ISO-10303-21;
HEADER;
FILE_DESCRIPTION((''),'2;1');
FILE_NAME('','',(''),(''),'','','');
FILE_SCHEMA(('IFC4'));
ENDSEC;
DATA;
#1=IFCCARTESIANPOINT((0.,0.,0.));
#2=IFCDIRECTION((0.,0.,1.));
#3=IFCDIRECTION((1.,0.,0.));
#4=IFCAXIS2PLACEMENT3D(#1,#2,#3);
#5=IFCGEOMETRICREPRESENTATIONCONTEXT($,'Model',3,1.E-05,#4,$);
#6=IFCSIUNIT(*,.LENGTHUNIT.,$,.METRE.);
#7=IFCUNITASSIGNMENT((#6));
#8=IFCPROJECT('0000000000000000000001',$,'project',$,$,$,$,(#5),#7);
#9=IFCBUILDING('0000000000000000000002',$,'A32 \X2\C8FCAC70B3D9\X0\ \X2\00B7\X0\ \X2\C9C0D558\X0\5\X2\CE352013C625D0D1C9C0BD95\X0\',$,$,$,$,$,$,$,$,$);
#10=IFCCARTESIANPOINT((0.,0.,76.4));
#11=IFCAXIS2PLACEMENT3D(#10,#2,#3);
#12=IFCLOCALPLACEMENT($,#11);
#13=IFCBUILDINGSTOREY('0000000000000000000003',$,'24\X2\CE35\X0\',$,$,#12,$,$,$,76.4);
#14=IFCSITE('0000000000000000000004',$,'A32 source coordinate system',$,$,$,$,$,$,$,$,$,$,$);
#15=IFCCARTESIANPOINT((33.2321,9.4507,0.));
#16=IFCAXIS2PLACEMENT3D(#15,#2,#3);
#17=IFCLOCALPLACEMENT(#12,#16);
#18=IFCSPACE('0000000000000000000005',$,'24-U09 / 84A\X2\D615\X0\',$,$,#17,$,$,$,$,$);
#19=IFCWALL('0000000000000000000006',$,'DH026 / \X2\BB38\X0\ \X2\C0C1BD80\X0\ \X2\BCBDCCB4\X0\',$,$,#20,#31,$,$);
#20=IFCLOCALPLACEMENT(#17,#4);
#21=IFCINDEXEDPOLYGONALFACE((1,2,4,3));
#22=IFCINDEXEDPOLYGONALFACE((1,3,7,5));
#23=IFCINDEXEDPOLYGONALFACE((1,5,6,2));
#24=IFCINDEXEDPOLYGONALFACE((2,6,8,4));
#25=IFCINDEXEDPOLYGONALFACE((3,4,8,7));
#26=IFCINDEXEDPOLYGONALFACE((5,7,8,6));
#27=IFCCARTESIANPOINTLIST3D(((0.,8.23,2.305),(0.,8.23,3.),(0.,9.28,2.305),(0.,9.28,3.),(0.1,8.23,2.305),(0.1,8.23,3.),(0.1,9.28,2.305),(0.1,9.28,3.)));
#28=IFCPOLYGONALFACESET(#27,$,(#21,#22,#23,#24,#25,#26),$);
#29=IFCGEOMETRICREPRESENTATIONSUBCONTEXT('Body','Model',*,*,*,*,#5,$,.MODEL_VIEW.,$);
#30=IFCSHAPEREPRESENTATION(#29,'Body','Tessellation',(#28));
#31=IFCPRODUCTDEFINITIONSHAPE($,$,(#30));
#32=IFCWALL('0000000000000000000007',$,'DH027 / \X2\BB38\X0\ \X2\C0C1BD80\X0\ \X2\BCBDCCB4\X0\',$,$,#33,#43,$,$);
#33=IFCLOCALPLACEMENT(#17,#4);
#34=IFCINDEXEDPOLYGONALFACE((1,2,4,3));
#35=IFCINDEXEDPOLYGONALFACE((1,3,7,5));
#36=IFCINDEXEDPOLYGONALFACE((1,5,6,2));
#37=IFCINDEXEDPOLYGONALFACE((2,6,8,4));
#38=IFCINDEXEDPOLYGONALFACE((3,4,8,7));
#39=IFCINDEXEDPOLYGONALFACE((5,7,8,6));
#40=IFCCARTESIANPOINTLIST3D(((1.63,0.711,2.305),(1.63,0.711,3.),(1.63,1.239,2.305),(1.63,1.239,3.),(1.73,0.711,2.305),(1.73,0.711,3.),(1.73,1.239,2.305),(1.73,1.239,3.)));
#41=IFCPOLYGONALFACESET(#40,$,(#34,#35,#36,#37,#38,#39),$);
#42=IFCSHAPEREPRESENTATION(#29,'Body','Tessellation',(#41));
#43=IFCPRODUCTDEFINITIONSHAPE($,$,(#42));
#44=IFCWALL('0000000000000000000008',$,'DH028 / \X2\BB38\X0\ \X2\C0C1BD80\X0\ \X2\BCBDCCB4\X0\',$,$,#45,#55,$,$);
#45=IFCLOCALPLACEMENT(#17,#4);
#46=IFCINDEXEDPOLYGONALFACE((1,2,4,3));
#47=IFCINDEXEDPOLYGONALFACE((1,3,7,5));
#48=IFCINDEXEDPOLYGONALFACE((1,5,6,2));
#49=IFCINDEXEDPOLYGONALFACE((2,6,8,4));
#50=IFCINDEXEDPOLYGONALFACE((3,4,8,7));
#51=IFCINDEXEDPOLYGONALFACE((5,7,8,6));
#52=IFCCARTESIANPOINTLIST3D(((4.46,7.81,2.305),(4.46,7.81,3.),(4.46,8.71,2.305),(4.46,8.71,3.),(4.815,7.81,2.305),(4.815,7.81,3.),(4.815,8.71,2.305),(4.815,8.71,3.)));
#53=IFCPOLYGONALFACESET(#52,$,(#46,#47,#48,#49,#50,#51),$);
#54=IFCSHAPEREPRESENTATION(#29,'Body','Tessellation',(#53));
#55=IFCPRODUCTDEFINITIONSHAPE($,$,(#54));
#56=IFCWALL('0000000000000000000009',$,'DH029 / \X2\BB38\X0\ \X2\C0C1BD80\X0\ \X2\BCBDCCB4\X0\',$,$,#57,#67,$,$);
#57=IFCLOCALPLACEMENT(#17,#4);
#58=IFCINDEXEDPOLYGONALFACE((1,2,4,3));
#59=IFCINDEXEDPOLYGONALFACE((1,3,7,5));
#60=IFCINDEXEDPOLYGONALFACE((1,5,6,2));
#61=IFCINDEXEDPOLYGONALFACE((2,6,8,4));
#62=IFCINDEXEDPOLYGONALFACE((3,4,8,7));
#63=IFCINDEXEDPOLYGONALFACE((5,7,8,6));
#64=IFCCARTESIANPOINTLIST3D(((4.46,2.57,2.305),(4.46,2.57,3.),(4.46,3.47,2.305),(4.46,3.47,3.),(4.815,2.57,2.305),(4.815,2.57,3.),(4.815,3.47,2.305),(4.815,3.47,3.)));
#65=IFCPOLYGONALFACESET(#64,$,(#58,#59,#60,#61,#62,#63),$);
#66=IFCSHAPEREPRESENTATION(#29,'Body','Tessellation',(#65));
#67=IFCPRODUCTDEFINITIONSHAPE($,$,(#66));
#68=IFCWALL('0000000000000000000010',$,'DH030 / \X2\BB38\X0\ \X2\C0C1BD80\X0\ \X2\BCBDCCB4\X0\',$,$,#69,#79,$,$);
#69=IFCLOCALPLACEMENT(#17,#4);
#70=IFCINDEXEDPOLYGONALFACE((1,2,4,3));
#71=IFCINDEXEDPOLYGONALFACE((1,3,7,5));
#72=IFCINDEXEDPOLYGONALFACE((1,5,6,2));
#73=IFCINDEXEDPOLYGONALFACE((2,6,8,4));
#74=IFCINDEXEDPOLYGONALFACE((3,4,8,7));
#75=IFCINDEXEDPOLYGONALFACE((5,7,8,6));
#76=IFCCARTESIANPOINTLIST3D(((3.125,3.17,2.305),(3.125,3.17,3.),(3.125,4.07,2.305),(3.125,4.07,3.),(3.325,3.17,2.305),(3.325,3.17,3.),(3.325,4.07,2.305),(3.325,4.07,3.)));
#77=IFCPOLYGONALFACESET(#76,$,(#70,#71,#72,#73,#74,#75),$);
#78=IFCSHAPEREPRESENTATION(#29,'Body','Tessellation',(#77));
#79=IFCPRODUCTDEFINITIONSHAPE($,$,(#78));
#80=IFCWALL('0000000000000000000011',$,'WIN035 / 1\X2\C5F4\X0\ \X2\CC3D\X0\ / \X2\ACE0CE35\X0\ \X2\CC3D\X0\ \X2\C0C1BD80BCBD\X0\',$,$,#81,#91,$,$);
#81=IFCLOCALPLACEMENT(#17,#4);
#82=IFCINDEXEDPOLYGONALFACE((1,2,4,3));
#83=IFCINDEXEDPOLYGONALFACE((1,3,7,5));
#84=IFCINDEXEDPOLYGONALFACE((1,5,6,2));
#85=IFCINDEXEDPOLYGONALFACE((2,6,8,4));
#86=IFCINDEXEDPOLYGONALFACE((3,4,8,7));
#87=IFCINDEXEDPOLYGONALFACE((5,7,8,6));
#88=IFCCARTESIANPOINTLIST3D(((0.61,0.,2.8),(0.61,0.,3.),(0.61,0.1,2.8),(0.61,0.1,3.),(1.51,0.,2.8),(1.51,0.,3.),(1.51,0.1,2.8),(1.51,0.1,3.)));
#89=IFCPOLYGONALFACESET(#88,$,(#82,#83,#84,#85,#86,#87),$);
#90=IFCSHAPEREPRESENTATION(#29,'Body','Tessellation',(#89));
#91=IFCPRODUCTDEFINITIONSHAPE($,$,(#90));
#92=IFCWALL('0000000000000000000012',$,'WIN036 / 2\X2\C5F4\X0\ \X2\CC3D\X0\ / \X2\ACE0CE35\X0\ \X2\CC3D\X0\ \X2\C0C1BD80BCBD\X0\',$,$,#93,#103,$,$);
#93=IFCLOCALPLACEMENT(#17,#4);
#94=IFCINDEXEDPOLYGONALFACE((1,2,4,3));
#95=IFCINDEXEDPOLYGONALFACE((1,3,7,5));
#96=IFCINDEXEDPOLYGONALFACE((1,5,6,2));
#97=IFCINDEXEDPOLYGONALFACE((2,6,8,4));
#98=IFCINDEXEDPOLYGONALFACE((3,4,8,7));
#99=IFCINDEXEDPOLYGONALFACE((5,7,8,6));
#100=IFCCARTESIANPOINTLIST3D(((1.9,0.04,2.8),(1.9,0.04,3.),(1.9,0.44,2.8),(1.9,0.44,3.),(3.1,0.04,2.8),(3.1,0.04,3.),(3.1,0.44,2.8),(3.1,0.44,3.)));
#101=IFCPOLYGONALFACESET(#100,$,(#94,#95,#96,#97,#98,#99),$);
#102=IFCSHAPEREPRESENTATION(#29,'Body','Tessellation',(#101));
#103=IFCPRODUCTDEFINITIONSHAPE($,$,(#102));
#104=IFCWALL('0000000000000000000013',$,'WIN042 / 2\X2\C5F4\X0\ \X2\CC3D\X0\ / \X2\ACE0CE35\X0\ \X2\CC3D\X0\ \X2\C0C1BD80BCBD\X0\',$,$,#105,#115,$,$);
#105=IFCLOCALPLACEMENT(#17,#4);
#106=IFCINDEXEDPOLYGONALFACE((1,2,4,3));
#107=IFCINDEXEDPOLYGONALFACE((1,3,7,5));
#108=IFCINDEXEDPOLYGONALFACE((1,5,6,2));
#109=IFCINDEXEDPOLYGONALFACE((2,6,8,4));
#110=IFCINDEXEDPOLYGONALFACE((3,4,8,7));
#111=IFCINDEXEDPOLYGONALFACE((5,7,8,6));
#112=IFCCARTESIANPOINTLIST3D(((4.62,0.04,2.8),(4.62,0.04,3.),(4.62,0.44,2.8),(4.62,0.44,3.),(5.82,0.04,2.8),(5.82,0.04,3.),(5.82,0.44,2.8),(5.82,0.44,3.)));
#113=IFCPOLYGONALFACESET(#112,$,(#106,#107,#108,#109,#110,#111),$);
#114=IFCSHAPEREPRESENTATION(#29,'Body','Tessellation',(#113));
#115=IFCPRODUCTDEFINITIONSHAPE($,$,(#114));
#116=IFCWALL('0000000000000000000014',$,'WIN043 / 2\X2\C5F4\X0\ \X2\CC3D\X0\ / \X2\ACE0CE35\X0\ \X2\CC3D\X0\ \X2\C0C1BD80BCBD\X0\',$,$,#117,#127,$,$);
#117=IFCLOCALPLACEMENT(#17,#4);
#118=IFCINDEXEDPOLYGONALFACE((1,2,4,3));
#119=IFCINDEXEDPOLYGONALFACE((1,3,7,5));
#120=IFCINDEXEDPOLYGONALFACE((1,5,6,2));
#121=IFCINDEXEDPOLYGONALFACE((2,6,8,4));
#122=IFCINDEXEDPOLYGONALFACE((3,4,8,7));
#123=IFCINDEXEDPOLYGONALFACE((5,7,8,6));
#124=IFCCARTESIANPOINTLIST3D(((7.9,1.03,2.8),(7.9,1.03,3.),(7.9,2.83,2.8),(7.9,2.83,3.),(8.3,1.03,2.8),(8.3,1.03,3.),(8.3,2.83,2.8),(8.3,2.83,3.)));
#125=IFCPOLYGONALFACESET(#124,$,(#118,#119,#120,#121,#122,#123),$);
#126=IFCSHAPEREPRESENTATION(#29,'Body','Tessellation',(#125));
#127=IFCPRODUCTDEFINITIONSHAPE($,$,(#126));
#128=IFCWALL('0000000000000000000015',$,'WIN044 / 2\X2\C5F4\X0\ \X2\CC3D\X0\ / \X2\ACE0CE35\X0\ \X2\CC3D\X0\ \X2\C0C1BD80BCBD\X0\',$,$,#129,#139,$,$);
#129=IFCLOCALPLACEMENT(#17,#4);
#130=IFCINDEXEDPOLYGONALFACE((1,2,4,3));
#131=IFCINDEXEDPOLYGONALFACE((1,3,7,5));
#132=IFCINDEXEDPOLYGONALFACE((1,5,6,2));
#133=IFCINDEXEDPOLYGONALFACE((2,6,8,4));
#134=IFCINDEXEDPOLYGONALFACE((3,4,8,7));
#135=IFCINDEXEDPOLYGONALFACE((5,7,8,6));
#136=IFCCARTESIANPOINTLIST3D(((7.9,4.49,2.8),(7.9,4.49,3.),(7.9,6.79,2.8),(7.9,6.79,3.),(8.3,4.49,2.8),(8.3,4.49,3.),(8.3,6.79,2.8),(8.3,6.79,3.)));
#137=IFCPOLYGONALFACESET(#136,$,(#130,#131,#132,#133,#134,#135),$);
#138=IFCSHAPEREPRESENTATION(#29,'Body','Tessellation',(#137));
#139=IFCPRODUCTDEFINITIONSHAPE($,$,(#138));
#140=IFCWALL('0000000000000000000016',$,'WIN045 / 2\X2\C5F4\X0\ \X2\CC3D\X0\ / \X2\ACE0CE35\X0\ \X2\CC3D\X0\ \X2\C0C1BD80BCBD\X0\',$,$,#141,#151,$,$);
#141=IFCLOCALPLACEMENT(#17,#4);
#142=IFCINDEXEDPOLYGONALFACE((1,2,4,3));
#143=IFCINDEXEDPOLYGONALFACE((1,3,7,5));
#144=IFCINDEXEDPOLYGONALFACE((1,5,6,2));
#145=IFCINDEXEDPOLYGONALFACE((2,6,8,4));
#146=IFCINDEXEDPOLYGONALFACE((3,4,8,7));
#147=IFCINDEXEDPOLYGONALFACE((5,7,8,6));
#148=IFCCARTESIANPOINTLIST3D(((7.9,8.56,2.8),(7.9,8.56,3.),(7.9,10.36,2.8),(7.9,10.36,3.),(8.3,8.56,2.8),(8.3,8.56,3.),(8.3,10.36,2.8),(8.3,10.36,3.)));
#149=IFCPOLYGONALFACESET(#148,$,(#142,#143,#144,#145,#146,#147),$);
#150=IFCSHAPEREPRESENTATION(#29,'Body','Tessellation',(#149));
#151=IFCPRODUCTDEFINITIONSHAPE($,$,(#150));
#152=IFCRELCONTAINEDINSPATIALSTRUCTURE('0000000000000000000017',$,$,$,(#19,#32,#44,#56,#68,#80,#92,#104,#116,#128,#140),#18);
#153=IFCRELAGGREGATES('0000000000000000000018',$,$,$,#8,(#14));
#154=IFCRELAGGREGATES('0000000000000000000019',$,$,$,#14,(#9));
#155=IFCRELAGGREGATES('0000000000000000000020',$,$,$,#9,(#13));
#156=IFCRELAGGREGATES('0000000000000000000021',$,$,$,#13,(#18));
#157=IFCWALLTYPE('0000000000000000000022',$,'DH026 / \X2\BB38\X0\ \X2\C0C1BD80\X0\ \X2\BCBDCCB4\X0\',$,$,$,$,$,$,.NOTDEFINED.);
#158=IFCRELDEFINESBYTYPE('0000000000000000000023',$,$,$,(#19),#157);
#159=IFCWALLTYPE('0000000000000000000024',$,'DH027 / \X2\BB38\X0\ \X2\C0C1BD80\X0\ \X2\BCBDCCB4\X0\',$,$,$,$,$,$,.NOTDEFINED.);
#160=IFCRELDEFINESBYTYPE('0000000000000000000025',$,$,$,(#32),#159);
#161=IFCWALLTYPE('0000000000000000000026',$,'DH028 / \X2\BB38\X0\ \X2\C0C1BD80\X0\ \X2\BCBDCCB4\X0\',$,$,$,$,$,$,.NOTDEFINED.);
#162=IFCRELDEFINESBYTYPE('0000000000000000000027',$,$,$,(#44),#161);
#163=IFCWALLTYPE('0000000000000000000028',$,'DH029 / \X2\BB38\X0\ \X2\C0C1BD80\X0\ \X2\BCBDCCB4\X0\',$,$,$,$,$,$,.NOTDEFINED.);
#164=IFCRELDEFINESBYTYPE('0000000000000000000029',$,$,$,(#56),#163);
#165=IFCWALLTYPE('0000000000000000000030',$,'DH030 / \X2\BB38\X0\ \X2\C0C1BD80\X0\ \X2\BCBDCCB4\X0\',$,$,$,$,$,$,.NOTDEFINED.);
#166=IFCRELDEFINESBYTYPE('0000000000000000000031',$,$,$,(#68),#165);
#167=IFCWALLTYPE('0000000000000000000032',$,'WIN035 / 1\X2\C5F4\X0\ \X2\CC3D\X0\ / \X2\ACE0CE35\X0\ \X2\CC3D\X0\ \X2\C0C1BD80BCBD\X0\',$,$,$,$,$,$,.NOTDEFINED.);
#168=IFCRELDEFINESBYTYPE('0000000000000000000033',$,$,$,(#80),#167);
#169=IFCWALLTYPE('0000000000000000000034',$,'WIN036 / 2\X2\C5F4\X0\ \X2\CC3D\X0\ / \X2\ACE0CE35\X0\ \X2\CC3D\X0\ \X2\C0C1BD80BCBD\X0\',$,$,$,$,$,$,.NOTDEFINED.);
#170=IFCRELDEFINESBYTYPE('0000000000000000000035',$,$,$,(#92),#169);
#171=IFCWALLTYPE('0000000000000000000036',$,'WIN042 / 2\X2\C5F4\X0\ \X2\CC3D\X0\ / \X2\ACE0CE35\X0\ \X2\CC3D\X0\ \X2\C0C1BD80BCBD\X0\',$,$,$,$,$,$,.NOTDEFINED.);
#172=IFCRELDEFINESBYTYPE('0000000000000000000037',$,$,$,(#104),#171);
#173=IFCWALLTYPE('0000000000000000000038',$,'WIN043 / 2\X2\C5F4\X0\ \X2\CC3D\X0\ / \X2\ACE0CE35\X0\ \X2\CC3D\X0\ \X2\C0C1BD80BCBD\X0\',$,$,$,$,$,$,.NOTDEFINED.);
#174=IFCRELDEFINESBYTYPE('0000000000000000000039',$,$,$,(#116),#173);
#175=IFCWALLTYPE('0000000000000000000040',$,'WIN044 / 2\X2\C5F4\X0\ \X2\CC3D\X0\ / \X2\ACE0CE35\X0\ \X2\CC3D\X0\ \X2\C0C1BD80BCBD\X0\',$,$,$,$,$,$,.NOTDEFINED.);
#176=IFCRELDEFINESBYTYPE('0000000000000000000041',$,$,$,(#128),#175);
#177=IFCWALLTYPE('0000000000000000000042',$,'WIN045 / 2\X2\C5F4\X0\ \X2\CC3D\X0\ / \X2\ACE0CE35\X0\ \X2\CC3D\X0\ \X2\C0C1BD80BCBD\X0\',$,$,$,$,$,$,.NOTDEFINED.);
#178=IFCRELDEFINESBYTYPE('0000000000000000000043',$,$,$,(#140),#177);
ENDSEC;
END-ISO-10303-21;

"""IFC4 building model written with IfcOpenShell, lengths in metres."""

from ifc_helpers import new_model, si_unit, frame, origin, origin_with_axes, place, context, subcontext, project, spatial, polyline, outline, extrude, source, transform, mapped, type_object, type_shapes, element, save


model = new_model("IFC4")

# Units and contexts
model_context = context("Model", 3, precision=1e-05, world=origin_with_axes())
body_context = subcontext(model_context, "Body", "Model", "MODEL_VIEW")
ifc_project = project(units=[si_unit("LENGTHUNIT", "METRE")], contexts=[model_context])

# Site, building, storey
storey_placement = place(None, frame((0.0, 0.0, 76.4), z_axis=(0.0, 0.0, 1.0), x_axis=(1.0, 0.0, 0.0)))
site = spatial("IfcSite", under=ifc_project, Name="A32 source coordinate system")
building = spatial("IfcBuilding", under=site, Name="A32 주거동 · 지하5층–옥탑지붕")
storey = spatial("IfcBuildingStorey", under=building, at=storey_placement, Name="24층", Elevation=76.4)

# Shared definitions
space_1_placement = place(storey_placement, frame((33.2321, 9.4507, 0.0), z_axis=(0.0, 0.0, 1.0), x_axis=(1.0, 0.0, 0.0)))
space_1 = spatial("IfcSpace", under=storey, at=space_1_placement, Name="24-U09 / 84A형")

# Walls
wall_type_1 = type_object("IfcWallType", Name="DH026 / 문 상부 벽체", PredefinedType="NOTDEFINED")
shared_shape_1 = source(origin(), body_context, "Body", "SweptSolid", [
    extrude(outline(polyline([(0.1, 9.28), (0.1, 8.23), (0.0, 8.23), (0.0, 9.28), (0.1, 9.28)])), frame((0.0, 0.0, 2.305)), (0.0, 0.0, 1.0), 0.695),
])
type_shapes(wall_type_1, [shared_shape_1])
wall_1_placement = place(space_1_placement, origin_with_axes())
element("IfcWall", 1, at=wall_1_placement, inside=space_1, type_object=wall_type_1, Name="DH026 / 문 상부 벽체", context=body_context, shape_type="MappedRepresentation", body=[
    mapped(shared_shape_1, transform((0.0, 0.0, 0.0), scale=1.0)),
])
wall_type_2 = type_object("IfcWallType", Name="DH027 / 문 상부 벽체", PredefinedType="NOTDEFINED")
shared_shape_2 = source(origin(), body_context, "Body", "SweptSolid", [
    extrude(outline(polyline([(1.63, 1.239), (1.73, 1.239), (1.73, 0.711), (1.63, 0.711), (1.63, 1.239)])), frame((0.0, 0.0, 2.305)), (0.0, 0.0, 1.0), 0.695),
])
type_shapes(wall_type_2, [shared_shape_2])
wall_2_placement = place(space_1_placement, origin_with_axes())
element("IfcWall", 2, at=wall_2_placement, inside=space_1, type_object=wall_type_2, Name="DH027 / 문 상부 벽체", context=body_context, shape_type="MappedRepresentation", body=[
    mapped(shared_shape_2, transform((0.0, 0.0, 0.0), scale=1.0)),
])
wall_type_3 = type_object("IfcWallType", Name="DH028 / 문 상부 벽체", PredefinedType="NOTDEFINED")
shared_shape_3 = source(origin(), body_context, "Body", "SweptSolid", [
    extrude(outline(polyline([(4.815, 8.71), (4.815, 7.81), (4.46, 7.81), (4.46, 8.71), (4.815, 8.71)])), frame((0.0, 0.0, 2.305)), (0.0, 0.0, 1.0), 0.695),
])
type_shapes(wall_type_3, [shared_shape_3])
wall_3_placement = place(space_1_placement, origin_with_axes())
element("IfcWall", 3, at=wall_3_placement, inside=space_1, type_object=wall_type_3, Name="DH028 / 문 상부 벽체", context=body_context, shape_type="MappedRepresentation", body=[
    mapped(shared_shape_3, transform((0.0, 0.0, 0.0), scale=1.0)),
])
wall_type_4 = type_object("IfcWallType", Name="DH029 / 문 상부 벽체", PredefinedType="NOTDEFINED")
shared_shape_4 = source(origin(), body_context, "Body", "SweptSolid", [
    extrude(outline(polyline([(4.815, 3.47), (4.815, 2.57), (4.46, 2.57), (4.46, 3.47), (4.815, 3.47)])), frame((0.0, 0.0, 2.305)), (0.0, 0.0, 1.0), 0.695),
])
type_shapes(wall_type_4, [shared_shape_4])
wall_4_placement = place(space_1_placement, origin_with_axes())
element("IfcWall", 4, at=wall_4_placement, inside=space_1, type_object=wall_type_4, Name="DH029 / 문 상부 벽체", context=body_context, shape_type="MappedRepresentation", body=[
    mapped(shared_shape_4, transform((0.0, 0.0, 0.0), scale=1.0)),
])
wall_type_5 = type_object("IfcWallType", Name="DH030 / 문 상부 벽체", PredefinedType="NOTDEFINED")
shared_shape_5 = source(origin(), body_context, "Body", "SweptSolid", [
    extrude(outline(polyline([(3.325, 4.07), (3.325, 3.17), (3.125, 3.17), (3.125, 4.07), (3.325, 4.07)])), frame((0.0, 0.0, 2.305)), (0.0, 0.0, 1.0), 0.695),
])
type_shapes(wall_type_5, [shared_shape_5])
wall_5_placement = place(space_1_placement, origin_with_axes())
element("IfcWall", 5, at=wall_5_placement, inside=space_1, type_object=wall_type_5, Name="DH030 / 문 상부 벽체", context=body_context, shape_type="MappedRepresentation", body=[
    mapped(shared_shape_5, transform((0.0, 0.0, 0.0), scale=1.0)),
])
wall_type_6 = type_object("IfcWallType", Name="WIN035 / 1열 창 / 고층 창 상부벽", PredefinedType="NOTDEFINED")
shared_shape_6 = source(origin(), body_context, "Body", "SweptSolid", [
    extrude(outline(polyline([(1.51, 0.0), (1.51, 0.1), (0.61, 0.1), (0.61, 0.0), (1.51, 0.0)])), frame((0.0, 0.0, 2.8)), (0.0, 0.0, 1.0), 0.2),
])
type_shapes(wall_type_6, [shared_shape_6])
wall_6_placement = place(space_1_placement, origin_with_axes())
element("IfcWall", 6, at=wall_6_placement, inside=space_1, type_object=wall_type_6, Name="WIN035 / 1열 창 / 고층 창 상부벽", context=body_context, shape_type="MappedRepresentation", body=[
    mapped(shared_shape_6, transform((0.0, 0.0, 0.0), scale=1.0)),
])
wall_type_7 = type_object("IfcWallType", Name="WIN036 / 2열 창 / 고층 창 상부벽", PredefinedType="NOTDEFINED")
shared_shape_7 = source(origin(), body_context, "Body", "SweptSolid", [
    extrude(outline(polyline([(3.1, 0.04), (3.1, 0.44), (1.9, 0.44), (1.9, 0.04), (3.1, 0.04)])), frame((0.0, 0.0, 2.8)), (0.0, 0.0, 1.0), 0.2),
])
type_shapes(wall_type_7, [shared_shape_7])
wall_7_placement = place(space_1_placement, origin_with_axes())
element("IfcWall", 7, at=wall_7_placement, inside=space_1, type_object=wall_type_7, Name="WIN036 / 2열 창 / 고층 창 상부벽", context=body_context, shape_type="MappedRepresentation", body=[
    mapped(shared_shape_7, transform((0.0, 0.0, 0.0), scale=1.0)),
])
wall_type_8 = type_object("IfcWallType", Name="WIN042 / 2열 창 / 고층 창 상부벽", PredefinedType="NOTDEFINED")
shared_shape_8 = source(origin(), body_context, "Body", "SweptSolid", [
    extrude(outline(polyline([(5.82, 0.04), (5.82, 0.44), (4.62, 0.44), (4.62, 0.04), (5.82, 0.04)])), frame((0.0, 0.0, 2.8)), (0.0, 0.0, 1.0), 0.2),
])
type_shapes(wall_type_8, [shared_shape_8])
wall_8_placement = place(space_1_placement, origin_with_axes())
element("IfcWall", 8, at=wall_8_placement, inside=space_1, type_object=wall_type_8, Name="WIN042 / 2열 창 / 고층 창 상부벽", context=body_context, shape_type="MappedRepresentation", body=[
    mapped(shared_shape_8, transform((0.0, 0.0, 0.0), scale=1.0)),
])
wall_type_9 = type_object("IfcWallType", Name="WIN043 / 2열 창 / 고층 창 상부벽", PredefinedType="NOTDEFINED")
shared_shape_9 = source(origin(), body_context, "Body", "SweptSolid", [
    extrude(outline(polyline([(8.3, 1.03), (8.3, 2.83), (7.9, 2.83), (7.9, 1.03), (8.3, 1.03)])), frame((0.0, 0.0, 2.8)), (0.0, 0.0, 1.0), 0.2),
])
type_shapes(wall_type_9, [shared_shape_9])
wall_9_placement = place(space_1_placement, origin_with_axes())
element("IfcWall", 9, at=wall_9_placement, inside=space_1, type_object=wall_type_9, Name="WIN043 / 2열 창 / 고층 창 상부벽", context=body_context, shape_type="MappedRepresentation", body=[
    mapped(shared_shape_9, transform((0.0, 0.0, 0.0), scale=1.0)),
])
wall_type_10 = type_object("IfcWallType", Name="WIN044 / 2열 창 / 고층 창 상부벽", PredefinedType="NOTDEFINED")
shared_shape_10 = source(origin(), body_context, "Body", "SweptSolid", [
    extrude(outline(polyline([(8.3, 4.49), (8.3, 6.79), (7.9, 6.79), (7.9, 4.49), (8.3, 4.49)])), frame((0.0, 0.0, 2.8)), (0.0, 0.0, 1.0), 0.2),
])
type_shapes(wall_type_10, [shared_shape_10])
wall_10_placement = place(space_1_placement, origin_with_axes())
element("IfcWall", 10, at=wall_10_placement, inside=space_1, type_object=wall_type_10, Name="WIN044 / 2열 창 / 고층 창 상부벽", context=body_context, shape_type="MappedRepresentation", body=[
    mapped(shared_shape_10, transform((0.0, 0.0, 0.0), scale=1.0)),
])
wall_type_11 = type_object("IfcWallType", Name="WIN045 / 2열 창 / 고층 창 상부벽", PredefinedType="NOTDEFINED")
shared_shape_11 = source(origin(), body_context, "Body", "SweptSolid", [
    extrude(outline(polyline([(8.3, 8.56), (8.3, 10.36), (7.9, 10.36), (7.9, 8.56), (8.3, 8.56)])), frame((0.0, 0.0, 2.8)), (0.0, 0.0, 1.0), 0.2),
])
type_shapes(wall_type_11, [shared_shape_11])
wall_11_placement = place(space_1_placement, origin_with_axes())
element("IfcWall", 11, at=wall_11_placement, inside=space_1, type_object=wall_type_11, Name="WIN045 / 2열 창 / 고층 창 상부벽", context=body_context, shape_type="MappedRepresentation", body=[
    mapped(shared_shape_11, transform((0.0, 0.0, 0.0), scale=1.0)),
])

save(model, "model.ifc")
